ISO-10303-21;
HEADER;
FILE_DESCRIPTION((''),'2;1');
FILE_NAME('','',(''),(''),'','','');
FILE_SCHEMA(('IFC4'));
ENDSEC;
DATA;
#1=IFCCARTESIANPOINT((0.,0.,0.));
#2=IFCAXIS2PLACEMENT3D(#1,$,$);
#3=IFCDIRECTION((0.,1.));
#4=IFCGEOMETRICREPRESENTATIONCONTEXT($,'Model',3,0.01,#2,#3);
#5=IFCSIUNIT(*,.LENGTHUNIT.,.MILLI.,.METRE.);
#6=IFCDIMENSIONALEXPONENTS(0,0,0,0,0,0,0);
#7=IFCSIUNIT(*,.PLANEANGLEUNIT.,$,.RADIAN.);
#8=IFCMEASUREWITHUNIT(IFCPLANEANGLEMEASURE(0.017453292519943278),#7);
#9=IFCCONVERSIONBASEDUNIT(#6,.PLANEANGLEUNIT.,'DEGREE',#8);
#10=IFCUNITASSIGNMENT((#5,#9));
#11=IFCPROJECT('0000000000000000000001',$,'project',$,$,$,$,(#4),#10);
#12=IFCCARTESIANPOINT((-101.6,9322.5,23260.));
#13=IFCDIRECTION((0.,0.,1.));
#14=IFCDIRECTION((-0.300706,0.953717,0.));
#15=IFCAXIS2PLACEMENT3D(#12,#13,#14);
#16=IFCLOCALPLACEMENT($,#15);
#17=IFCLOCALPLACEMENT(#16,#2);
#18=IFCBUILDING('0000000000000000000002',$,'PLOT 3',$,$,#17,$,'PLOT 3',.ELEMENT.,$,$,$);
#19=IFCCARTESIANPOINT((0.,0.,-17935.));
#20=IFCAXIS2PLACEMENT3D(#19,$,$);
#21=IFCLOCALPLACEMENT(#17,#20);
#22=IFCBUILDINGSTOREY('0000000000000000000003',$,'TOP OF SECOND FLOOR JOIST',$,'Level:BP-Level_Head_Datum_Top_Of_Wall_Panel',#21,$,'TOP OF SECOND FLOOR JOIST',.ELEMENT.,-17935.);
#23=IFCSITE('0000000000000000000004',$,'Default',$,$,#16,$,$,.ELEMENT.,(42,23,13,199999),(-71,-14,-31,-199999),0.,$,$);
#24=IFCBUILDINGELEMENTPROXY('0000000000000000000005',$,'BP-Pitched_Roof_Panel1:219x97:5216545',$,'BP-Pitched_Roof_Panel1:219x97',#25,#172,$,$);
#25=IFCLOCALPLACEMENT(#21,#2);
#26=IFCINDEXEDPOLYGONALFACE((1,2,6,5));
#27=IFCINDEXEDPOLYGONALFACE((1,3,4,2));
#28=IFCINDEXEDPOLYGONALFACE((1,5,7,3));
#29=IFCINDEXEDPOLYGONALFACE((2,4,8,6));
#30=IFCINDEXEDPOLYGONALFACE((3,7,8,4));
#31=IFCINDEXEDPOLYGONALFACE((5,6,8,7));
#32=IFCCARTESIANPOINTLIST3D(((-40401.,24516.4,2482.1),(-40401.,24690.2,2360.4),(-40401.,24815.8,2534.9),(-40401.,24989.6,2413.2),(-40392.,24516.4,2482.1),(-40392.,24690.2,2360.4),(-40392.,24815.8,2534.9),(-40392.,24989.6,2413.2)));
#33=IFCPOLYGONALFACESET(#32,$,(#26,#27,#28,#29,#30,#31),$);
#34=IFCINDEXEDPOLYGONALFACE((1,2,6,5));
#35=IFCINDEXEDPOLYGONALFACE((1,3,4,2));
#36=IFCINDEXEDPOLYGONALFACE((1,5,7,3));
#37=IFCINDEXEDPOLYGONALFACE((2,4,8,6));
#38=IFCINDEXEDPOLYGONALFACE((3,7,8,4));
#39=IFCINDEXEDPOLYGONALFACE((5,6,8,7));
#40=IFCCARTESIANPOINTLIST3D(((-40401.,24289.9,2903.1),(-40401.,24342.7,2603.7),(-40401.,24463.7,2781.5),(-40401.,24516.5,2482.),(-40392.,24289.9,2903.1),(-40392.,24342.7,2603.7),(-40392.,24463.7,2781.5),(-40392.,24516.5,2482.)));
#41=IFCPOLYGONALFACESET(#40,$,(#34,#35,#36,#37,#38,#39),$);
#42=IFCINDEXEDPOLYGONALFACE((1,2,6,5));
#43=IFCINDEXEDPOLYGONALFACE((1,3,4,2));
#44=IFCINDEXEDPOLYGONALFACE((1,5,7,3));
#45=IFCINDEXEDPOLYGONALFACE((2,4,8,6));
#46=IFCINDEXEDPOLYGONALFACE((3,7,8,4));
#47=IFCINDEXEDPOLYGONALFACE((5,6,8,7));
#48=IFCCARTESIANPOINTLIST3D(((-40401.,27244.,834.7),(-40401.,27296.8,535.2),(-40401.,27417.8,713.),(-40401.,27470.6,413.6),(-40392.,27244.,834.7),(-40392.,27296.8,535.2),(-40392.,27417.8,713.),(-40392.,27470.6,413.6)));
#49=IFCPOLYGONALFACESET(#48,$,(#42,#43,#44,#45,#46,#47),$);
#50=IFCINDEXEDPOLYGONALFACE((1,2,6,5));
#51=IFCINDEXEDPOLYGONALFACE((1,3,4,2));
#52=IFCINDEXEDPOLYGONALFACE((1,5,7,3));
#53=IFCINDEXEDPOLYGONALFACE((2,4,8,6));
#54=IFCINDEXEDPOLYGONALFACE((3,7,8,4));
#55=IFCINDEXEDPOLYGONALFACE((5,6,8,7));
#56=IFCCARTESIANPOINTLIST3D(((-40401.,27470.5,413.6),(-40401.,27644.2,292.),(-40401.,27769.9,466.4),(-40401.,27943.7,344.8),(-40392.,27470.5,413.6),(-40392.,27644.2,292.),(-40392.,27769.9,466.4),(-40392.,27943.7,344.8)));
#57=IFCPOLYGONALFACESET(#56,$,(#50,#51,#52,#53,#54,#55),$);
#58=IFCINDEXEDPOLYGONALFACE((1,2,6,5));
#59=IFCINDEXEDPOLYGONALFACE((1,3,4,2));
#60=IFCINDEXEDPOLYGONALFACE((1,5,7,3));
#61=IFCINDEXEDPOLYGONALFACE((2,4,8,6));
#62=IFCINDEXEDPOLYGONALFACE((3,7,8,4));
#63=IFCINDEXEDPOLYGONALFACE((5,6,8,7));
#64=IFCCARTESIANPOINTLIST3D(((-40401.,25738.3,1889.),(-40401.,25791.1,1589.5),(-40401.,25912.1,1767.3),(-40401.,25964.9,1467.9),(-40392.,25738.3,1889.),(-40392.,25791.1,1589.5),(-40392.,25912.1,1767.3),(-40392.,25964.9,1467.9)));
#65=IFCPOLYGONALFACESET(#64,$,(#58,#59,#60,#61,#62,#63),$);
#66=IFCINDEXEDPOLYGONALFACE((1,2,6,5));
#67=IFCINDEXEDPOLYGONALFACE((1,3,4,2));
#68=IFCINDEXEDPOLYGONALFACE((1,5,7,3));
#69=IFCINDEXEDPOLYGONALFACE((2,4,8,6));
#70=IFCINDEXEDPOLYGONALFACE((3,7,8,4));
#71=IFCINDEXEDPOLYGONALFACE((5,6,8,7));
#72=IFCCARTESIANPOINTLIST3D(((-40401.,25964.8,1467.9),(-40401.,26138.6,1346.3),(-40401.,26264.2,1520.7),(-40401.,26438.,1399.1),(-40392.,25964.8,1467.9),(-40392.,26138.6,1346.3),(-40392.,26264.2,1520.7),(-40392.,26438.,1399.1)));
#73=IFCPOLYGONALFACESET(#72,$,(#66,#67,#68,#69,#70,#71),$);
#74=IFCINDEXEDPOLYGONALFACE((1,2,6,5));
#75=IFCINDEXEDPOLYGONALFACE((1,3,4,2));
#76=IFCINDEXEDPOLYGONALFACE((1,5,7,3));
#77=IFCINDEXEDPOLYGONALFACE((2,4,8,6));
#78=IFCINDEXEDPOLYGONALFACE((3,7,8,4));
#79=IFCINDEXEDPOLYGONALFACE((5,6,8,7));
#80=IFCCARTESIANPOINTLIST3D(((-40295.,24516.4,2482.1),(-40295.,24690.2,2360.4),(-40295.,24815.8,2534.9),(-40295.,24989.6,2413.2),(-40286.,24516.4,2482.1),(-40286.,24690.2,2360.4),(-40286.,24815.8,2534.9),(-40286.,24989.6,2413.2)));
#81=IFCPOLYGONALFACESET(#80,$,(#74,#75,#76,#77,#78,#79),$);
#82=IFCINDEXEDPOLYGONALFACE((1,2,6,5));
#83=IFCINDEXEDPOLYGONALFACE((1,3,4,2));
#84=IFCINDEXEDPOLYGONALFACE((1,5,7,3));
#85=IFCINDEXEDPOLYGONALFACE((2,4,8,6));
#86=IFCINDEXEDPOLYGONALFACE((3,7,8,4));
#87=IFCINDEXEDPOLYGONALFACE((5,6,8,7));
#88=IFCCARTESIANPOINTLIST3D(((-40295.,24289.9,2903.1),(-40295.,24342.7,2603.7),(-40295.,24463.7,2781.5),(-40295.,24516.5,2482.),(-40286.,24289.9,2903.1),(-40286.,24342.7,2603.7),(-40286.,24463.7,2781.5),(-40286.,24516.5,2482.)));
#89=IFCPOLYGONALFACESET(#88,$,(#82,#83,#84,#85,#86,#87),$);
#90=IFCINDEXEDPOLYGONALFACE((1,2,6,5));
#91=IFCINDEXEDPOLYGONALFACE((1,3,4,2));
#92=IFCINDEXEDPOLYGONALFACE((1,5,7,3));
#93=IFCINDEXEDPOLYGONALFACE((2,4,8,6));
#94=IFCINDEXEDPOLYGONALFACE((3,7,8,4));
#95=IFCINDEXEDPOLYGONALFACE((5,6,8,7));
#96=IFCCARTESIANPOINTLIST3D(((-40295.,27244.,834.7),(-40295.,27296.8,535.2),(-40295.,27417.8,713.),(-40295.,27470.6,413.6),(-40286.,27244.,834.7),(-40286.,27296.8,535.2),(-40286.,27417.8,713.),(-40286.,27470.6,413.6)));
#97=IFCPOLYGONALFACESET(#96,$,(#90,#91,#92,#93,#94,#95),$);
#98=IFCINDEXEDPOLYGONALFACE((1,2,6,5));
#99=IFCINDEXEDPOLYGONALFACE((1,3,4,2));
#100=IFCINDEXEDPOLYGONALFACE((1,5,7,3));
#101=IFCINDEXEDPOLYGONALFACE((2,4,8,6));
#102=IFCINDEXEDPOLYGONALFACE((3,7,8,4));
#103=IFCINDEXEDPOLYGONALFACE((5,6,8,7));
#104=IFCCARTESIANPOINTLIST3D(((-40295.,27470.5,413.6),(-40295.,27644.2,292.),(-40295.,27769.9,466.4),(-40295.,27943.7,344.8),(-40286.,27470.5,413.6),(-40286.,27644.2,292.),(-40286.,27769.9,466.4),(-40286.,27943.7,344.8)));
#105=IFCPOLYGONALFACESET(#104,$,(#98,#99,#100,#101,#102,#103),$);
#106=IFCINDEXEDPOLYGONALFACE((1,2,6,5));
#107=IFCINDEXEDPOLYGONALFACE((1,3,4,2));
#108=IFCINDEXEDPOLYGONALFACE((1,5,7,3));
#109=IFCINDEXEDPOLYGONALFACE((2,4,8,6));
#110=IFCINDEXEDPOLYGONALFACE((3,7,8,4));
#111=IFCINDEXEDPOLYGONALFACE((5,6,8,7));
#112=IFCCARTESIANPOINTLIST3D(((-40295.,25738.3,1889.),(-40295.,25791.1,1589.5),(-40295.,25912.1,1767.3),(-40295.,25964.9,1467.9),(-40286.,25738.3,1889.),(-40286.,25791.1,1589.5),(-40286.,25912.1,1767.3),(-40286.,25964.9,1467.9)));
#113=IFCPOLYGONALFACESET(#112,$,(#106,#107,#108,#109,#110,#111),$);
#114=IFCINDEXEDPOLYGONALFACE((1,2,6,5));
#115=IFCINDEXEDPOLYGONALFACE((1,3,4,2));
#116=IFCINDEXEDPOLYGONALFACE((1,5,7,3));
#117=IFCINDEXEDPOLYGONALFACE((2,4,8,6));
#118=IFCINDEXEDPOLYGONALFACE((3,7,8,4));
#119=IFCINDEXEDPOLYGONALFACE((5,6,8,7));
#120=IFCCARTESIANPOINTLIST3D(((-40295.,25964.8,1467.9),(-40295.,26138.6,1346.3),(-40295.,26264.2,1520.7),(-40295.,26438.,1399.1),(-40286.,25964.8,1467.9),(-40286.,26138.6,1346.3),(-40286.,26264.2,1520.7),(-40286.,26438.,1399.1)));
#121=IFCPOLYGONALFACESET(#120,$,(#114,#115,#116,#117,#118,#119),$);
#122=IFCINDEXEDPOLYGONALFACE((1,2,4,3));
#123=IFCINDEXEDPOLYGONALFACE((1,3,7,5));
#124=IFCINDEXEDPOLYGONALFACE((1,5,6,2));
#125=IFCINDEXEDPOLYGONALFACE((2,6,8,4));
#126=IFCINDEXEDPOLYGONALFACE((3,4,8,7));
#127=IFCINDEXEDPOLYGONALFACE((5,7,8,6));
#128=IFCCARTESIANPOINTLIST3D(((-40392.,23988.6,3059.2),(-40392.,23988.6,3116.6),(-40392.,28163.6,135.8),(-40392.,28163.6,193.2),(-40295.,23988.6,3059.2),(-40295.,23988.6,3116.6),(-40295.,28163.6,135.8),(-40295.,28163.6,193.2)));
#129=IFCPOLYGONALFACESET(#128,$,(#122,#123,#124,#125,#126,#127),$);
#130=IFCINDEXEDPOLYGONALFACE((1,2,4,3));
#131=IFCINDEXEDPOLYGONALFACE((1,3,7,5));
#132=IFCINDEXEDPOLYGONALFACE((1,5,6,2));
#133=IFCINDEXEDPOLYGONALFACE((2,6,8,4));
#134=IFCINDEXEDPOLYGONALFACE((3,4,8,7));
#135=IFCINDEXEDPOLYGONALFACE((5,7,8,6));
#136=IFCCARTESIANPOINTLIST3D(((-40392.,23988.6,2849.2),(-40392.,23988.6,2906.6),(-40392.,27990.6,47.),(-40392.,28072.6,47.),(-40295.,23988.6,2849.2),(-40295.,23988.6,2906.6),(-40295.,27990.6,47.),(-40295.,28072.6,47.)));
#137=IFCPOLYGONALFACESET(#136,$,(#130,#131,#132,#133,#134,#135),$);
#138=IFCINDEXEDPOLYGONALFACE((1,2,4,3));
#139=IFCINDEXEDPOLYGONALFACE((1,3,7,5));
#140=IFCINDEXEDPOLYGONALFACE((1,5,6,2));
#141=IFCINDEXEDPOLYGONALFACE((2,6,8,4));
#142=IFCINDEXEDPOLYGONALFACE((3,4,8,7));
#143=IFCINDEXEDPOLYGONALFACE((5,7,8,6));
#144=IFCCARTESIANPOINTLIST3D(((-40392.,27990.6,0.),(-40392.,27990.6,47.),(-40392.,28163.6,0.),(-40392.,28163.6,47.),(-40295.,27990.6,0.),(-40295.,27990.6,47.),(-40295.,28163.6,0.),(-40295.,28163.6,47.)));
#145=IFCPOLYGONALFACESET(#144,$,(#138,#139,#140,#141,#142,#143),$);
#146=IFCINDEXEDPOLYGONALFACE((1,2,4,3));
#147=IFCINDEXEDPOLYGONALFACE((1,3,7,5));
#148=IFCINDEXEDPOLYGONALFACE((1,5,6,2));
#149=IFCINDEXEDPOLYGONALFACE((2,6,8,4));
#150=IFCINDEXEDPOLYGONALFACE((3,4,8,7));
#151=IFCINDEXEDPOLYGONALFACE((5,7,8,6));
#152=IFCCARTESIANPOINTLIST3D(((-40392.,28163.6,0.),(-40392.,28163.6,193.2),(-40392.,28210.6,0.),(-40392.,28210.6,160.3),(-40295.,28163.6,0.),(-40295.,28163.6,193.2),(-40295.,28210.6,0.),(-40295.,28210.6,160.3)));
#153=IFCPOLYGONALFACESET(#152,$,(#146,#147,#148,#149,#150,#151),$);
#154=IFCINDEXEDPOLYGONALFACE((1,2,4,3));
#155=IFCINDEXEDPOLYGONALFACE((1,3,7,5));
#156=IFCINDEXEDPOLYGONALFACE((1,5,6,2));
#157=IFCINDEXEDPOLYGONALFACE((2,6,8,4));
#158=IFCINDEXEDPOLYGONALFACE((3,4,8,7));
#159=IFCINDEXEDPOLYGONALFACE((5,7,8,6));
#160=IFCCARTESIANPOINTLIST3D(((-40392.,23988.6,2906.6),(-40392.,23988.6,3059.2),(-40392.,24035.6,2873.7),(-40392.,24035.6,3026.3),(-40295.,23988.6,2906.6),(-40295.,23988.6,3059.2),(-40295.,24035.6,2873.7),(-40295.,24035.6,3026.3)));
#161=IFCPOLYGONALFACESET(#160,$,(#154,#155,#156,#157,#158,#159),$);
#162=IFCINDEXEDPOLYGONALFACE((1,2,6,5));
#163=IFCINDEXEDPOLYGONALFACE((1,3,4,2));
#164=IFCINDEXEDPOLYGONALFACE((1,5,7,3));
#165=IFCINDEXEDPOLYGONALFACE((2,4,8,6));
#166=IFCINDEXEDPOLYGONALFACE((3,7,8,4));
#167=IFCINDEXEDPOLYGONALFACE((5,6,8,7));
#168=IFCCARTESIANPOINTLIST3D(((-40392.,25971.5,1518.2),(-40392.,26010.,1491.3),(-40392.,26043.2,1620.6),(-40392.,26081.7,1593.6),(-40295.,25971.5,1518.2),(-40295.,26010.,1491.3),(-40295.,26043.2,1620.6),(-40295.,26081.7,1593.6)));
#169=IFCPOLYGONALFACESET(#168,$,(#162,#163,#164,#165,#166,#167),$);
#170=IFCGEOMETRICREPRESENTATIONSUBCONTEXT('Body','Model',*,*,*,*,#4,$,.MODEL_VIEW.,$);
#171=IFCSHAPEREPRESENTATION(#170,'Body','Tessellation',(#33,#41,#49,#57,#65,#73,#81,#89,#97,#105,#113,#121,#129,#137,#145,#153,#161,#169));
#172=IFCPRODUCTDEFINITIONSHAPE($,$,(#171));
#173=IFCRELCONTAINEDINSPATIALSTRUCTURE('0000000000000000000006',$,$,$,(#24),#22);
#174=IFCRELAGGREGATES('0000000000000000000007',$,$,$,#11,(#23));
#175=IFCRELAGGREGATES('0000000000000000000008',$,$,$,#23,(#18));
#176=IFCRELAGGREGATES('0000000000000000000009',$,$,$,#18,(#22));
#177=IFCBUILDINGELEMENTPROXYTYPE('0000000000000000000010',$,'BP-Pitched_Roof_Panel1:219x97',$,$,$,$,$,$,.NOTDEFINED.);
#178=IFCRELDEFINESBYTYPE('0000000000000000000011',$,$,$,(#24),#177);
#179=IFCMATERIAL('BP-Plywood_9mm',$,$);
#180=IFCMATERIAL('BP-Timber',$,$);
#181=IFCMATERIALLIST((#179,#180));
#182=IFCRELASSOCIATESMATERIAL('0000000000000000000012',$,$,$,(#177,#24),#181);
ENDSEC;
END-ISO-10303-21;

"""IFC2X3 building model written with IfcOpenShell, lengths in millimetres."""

from ifc_helpers import new_model, entity, si_unit, converted_unit, direction, frame, frame_2d, origin, origin_2d_with_axis, place, context, subcontext, project, spatial, polyline, rectangle, outline, extrude, source, transform, mapped, material, material_list, type_object, type_shapes, element, save


model = new_model("IFC2X3")

# Units and contexts
model_context = context("Model", 3, precision=0.01, world=origin(), true_north=direction((0.0, 1.0)))
body_context = subcontext(model_context, "Body", "Model", "MODEL_VIEW")
ifc_project = project(units=[si_unit("LENGTHUNIT", "METRE", prefix="MILLI"), converted_unit("PLANEANGLEUNIT", "DEGREE", entity("IfcPlaneAngleMeasure", 0.017453292519943278), si_unit("PLANEANGLEUNIT", "RADIAN"), dimensions=[0, 0, 0, 0, 0, 0, 0])], contexts=[model_context])

# Site, building, storey
site_placement = place(None, frame((-101.6, 9322.5, 23260.0), z_axis=(0.0, 0.0, 1.0), x_axis=(-0.300706, 0.953717, 0.0)))
site = spatial("IfcSite", under=ifc_project, at=site_placement, Name="Default", CompositionType="ELEMENT", RefLatitude=(42, 23, 13, 199999), RefLongitude=(-71, -14, -31, -199999), RefElevation=0.0)
building_placement = place(site_placement, origin())
building = spatial("IfcBuilding", under=site, at=building_placement, Name="PLOT 3", LongName="PLOT 3", CompositionType="ELEMENT")
storey_placement = place(building_placement, frame((0.0, 0.0, -17935.0)))
storey = spatial("IfcBuildingStorey", under=building, at=storey_placement, Name="TOP OF SECOND FLOOR JOIST", ObjectType="Level:BP-Level_Head_Datum_Top_Of_Wall_Panel", LongName="TOP OF SECOND FLOOR JOIST", CompositionType="ELEMENT", Elevation=-17935.0)

# Building element proxy
ifc_material_1 = material(Name="BP-Timber")
ifc_material_2 = material(Name="BP-Plywood_9mm")
ifc_material_list = material_list([ifc_material_2, ifc_material_1])
building_element_proxy_type_1 = type_object("IfcBuildingElementProxyType", Name="BP-Pitched_Roof_Panel1:219x97", PredefinedType="NOTDEFINED", material=ifc_material_list)
shared_shape_1 = source(origin(), body_context, "Body", "SweptSolid", [
    extrude(outline(polyline([(-77.0, -75.0), (227.0, -75.0), (77.0, 75.0), (-227.0, 75.0), (-77.0, -75.0)])), frame((35.3, -3956.0, 2447.7), z_axis=(0.0, 1.0, 0.0), x_axis=(-0.984808, 0.0, 0.173648)), (0.0, 0.0, 1.0), 9.0),
    extrude(outline(polyline([(1.4, -107.5), (213.6, -107.5), (-1.4, 107.5), (-213.6, 107.5), (1.4, -107.5)])), frame((385.1, -3956.0, 2692.6), z_axis=(0.0, 1.0, 0.0), x_axis=(-0.819152, 0.0, -0.573576)), (0.0, 0.0, 1.0), 9.0),
    extrude(outline(polyline([(1.4, -107.5), (213.6, -107.5), (-1.4, 107.5), (-213.6, 107.5), (1.4, -107.5)])), frame((-2569.0, -3956.0, 624.1), z_axis=(0.0, 1.0, 0.0), x_axis=(-0.819152, 0.0, -0.573576)), (0.0, 0.0, 1.0), 9.0),
    extrude(outline(polyline([(-77.0, -75.0), (227.0, -75.0), (77.0, 75.0), (-227.0, 75.0), (-77.0, -75.0)])), frame((-2918.8, -3956.0, 379.2), z_axis=(0.0, 1.0, 0.0), x_axis=(-0.984808, 0.0, 0.173648)), (0.0, 0.0, 1.0), 9.0),
    extrude(outline(polyline([(1.4, -107.5), (213.6, -107.5), (-1.4, 107.5), (-213.6, 107.5), (1.4, -107.5)])), frame((-1063.3, -3956.0, 1678.4), z_axis=(0.0, 1.0, 0.0), x_axis=(-0.819152, 0.0, -0.573576)), (0.0, 0.0, 1.0), 9.0),
    extrude(outline(polyline([(-77.0, -75.0), (227.0, -75.0), (77.0, 75.0), (-227.0, 75.0), (-77.0, -75.0)])), frame((-1413.1, -3956.0, 1433.5), z_axis=(0.0, 1.0, 0.0), x_axis=(-0.984808, 0.0, 0.173648)), (0.0, 0.0, 1.0), 9.0),
    extrude(outline(polyline([(-77.0, -75.0), (227.0, -75.0), (77.0, 75.0), (-227.0, 75.0), (-77.0, -75.0)])), frame((35.3, -3850.0, 2447.7), z_axis=(0.0, 1.0, 0.0), x_axis=(-0.984808, 0.0, 0.173648)), (0.0, 0.0, 1.0), 9.0),
    extrude(outline(polyline([(1.4, -107.5), (213.6, -107.5), (-1.4, 107.5), (-213.6, 107.5), (1.4, -107.5)])), frame((385.1, -3850.0, 2692.6), z_axis=(0.0, 1.0, 0.0), x_axis=(-0.819152, 0.0, -0.573576)), (0.0, 0.0, 1.0), 9.0),
    extrude(outline(polyline([(1.4, -107.5), (213.6, -107.5), (-1.4, 107.5), (-213.6, 107.5), (1.4, -107.5)])), frame((-2569.0, -3850.0, 624.1), z_axis=(0.0, 1.0, 0.0), x_axis=(-0.819152, 0.0, -0.573576)), (0.0, 0.0, 1.0), 9.0),
    extrude(outline(polyline([(-77.0, -75.0), (227.0, -75.0), (77.0, 75.0), (-227.0, 75.0), (-77.0, -75.0)])), frame((-2918.8, -3850.0, 379.2), z_axis=(0.0, 1.0, 0.0), x_axis=(-0.984808, 0.0, 0.173648)), (0.0, 0.0, 1.0), 9.0),
    extrude(outline(polyline([(1.4, -107.5), (213.6, -107.5), (-1.4, 107.5), (-213.6, 107.5), (1.4, -107.5)])), frame((-1063.3, -3850.0, 1678.4), z_axis=(0.0, 1.0, 0.0), x_axis=(-0.819152, 0.0, -0.573576)), (0.0, 0.0, 1.0), 9.0),
    extrude(outline(polyline([(-77.0, -75.0), (227.0, -75.0), (77.0, 75.0), (-227.0, 75.0), (-77.0, -75.0)])), frame((-1413.1, -3850.0, 1433.5), z_axis=(0.0, 1.0, 0.0), x_axis=(-0.984808, 0.0, 0.173648)), (0.0, 0.0, 1.0), 9.0),
    extrude(outline(polyline([(-1490.4, -2087.5), (-1433.0, -2087.5), (1490.4, 2087.5), (1433.0, 2087.5), (-1490.4, -2087.5)])), frame((-1287.8, -3947.0, 1626.2), z_axis=(0.0, 1.0, 0.0), x_axis=(0.0, 0.0, -1.0)), (0.0, 0.0, 1.0), 97.0),
    extrude(outline(polyline([(-1444.1, -2021.5), (-1386.8, -2021.5), (1415.5, 1980.5), (1415.5, 2062.5), (-1444.1, -2021.5)])), frame((-1221.8, -3947.0, 1462.5), z_axis=(0.0, 1.0, 0.0), x_axis=(0.0, 0.0, -1.0)), (0.0, 0.0, 1.0), 97.0),
    extrude(rectangle(XDim=173.0, YDim=97.0, at=origin_2d_with_axis()), frame((-3288.8, -3898.5, 0.0), z_axis=(0.0, 0.0, 1.0), x_axis=(-1.0, 0.0, 0.0)), (0.0, 0.0, 1.0), 47.0),
    extrude(outline(polyline([(22.0, -72.4), (79.4, -72.4), (-31.4, 85.9), (-69.9, 58.9), (22.0, -72.4)])), frame((-3398.8, -3947.0, 88.4), z_axis=(0.0, 1.0, 0.0), x_axis=(0.819152, 0.0, 0.573576)), (0.0, 0.0, 1.0), 97.0),
    extrude(outline(polyline([(15.1, -62.5), (72.5, -62.5), (-15.1, 62.5), (-72.5, 62.5), (15.1, -62.5)])), frame((776.2, -3947.0, 2966.5), z_axis=(0.0, 1.0, 0.0), x_axis=(0.819152, 0.0, 0.573576)), (0.0, 0.0, 1.0), 97.0),
    extrude(rectangle(XDim=47.0, YDim=97.0, at=frame_2d((0.0, 0.0), x_axis=(1.0, 0.0))), frame((-1202.4, -3898.5, 1504.7), z_axis=(-0.573576, 0.0, 0.819152), x_axis=(-0.819152, 0.0, -0.573576)), (0.0, 0.0, 1.0), 125.0),
])
type_shapes(building_element_proxy_type_1, [shared_shape_1])
for number, where, z_axis, x_axis, name in (
    (1, (-36445.0, 24788.3, 0.0), (0.0, 0.0, 1.0), (0.0, -1.0, 0.0), "BP-Pitched_Roof_Panel1:219x97:5216545"),
):
    element("IfcBuildingElementProxy", number, at=place(storey_placement, frame(where, z_axis=z_axis, x_axis=x_axis)), inside=storey, type_object=building_element_proxy_type_1, material=ifc_material_list, Name=name, ObjectType="BP-Pitched_Roof_Panel1:219x97", context=body_context, shape_type="MappedRepresentation", body=[
        mapped(shared_shape_1, transform((0.0, 0.0, 0.0), scale=1.0)),
    ])

save(model, "model.ifc")
